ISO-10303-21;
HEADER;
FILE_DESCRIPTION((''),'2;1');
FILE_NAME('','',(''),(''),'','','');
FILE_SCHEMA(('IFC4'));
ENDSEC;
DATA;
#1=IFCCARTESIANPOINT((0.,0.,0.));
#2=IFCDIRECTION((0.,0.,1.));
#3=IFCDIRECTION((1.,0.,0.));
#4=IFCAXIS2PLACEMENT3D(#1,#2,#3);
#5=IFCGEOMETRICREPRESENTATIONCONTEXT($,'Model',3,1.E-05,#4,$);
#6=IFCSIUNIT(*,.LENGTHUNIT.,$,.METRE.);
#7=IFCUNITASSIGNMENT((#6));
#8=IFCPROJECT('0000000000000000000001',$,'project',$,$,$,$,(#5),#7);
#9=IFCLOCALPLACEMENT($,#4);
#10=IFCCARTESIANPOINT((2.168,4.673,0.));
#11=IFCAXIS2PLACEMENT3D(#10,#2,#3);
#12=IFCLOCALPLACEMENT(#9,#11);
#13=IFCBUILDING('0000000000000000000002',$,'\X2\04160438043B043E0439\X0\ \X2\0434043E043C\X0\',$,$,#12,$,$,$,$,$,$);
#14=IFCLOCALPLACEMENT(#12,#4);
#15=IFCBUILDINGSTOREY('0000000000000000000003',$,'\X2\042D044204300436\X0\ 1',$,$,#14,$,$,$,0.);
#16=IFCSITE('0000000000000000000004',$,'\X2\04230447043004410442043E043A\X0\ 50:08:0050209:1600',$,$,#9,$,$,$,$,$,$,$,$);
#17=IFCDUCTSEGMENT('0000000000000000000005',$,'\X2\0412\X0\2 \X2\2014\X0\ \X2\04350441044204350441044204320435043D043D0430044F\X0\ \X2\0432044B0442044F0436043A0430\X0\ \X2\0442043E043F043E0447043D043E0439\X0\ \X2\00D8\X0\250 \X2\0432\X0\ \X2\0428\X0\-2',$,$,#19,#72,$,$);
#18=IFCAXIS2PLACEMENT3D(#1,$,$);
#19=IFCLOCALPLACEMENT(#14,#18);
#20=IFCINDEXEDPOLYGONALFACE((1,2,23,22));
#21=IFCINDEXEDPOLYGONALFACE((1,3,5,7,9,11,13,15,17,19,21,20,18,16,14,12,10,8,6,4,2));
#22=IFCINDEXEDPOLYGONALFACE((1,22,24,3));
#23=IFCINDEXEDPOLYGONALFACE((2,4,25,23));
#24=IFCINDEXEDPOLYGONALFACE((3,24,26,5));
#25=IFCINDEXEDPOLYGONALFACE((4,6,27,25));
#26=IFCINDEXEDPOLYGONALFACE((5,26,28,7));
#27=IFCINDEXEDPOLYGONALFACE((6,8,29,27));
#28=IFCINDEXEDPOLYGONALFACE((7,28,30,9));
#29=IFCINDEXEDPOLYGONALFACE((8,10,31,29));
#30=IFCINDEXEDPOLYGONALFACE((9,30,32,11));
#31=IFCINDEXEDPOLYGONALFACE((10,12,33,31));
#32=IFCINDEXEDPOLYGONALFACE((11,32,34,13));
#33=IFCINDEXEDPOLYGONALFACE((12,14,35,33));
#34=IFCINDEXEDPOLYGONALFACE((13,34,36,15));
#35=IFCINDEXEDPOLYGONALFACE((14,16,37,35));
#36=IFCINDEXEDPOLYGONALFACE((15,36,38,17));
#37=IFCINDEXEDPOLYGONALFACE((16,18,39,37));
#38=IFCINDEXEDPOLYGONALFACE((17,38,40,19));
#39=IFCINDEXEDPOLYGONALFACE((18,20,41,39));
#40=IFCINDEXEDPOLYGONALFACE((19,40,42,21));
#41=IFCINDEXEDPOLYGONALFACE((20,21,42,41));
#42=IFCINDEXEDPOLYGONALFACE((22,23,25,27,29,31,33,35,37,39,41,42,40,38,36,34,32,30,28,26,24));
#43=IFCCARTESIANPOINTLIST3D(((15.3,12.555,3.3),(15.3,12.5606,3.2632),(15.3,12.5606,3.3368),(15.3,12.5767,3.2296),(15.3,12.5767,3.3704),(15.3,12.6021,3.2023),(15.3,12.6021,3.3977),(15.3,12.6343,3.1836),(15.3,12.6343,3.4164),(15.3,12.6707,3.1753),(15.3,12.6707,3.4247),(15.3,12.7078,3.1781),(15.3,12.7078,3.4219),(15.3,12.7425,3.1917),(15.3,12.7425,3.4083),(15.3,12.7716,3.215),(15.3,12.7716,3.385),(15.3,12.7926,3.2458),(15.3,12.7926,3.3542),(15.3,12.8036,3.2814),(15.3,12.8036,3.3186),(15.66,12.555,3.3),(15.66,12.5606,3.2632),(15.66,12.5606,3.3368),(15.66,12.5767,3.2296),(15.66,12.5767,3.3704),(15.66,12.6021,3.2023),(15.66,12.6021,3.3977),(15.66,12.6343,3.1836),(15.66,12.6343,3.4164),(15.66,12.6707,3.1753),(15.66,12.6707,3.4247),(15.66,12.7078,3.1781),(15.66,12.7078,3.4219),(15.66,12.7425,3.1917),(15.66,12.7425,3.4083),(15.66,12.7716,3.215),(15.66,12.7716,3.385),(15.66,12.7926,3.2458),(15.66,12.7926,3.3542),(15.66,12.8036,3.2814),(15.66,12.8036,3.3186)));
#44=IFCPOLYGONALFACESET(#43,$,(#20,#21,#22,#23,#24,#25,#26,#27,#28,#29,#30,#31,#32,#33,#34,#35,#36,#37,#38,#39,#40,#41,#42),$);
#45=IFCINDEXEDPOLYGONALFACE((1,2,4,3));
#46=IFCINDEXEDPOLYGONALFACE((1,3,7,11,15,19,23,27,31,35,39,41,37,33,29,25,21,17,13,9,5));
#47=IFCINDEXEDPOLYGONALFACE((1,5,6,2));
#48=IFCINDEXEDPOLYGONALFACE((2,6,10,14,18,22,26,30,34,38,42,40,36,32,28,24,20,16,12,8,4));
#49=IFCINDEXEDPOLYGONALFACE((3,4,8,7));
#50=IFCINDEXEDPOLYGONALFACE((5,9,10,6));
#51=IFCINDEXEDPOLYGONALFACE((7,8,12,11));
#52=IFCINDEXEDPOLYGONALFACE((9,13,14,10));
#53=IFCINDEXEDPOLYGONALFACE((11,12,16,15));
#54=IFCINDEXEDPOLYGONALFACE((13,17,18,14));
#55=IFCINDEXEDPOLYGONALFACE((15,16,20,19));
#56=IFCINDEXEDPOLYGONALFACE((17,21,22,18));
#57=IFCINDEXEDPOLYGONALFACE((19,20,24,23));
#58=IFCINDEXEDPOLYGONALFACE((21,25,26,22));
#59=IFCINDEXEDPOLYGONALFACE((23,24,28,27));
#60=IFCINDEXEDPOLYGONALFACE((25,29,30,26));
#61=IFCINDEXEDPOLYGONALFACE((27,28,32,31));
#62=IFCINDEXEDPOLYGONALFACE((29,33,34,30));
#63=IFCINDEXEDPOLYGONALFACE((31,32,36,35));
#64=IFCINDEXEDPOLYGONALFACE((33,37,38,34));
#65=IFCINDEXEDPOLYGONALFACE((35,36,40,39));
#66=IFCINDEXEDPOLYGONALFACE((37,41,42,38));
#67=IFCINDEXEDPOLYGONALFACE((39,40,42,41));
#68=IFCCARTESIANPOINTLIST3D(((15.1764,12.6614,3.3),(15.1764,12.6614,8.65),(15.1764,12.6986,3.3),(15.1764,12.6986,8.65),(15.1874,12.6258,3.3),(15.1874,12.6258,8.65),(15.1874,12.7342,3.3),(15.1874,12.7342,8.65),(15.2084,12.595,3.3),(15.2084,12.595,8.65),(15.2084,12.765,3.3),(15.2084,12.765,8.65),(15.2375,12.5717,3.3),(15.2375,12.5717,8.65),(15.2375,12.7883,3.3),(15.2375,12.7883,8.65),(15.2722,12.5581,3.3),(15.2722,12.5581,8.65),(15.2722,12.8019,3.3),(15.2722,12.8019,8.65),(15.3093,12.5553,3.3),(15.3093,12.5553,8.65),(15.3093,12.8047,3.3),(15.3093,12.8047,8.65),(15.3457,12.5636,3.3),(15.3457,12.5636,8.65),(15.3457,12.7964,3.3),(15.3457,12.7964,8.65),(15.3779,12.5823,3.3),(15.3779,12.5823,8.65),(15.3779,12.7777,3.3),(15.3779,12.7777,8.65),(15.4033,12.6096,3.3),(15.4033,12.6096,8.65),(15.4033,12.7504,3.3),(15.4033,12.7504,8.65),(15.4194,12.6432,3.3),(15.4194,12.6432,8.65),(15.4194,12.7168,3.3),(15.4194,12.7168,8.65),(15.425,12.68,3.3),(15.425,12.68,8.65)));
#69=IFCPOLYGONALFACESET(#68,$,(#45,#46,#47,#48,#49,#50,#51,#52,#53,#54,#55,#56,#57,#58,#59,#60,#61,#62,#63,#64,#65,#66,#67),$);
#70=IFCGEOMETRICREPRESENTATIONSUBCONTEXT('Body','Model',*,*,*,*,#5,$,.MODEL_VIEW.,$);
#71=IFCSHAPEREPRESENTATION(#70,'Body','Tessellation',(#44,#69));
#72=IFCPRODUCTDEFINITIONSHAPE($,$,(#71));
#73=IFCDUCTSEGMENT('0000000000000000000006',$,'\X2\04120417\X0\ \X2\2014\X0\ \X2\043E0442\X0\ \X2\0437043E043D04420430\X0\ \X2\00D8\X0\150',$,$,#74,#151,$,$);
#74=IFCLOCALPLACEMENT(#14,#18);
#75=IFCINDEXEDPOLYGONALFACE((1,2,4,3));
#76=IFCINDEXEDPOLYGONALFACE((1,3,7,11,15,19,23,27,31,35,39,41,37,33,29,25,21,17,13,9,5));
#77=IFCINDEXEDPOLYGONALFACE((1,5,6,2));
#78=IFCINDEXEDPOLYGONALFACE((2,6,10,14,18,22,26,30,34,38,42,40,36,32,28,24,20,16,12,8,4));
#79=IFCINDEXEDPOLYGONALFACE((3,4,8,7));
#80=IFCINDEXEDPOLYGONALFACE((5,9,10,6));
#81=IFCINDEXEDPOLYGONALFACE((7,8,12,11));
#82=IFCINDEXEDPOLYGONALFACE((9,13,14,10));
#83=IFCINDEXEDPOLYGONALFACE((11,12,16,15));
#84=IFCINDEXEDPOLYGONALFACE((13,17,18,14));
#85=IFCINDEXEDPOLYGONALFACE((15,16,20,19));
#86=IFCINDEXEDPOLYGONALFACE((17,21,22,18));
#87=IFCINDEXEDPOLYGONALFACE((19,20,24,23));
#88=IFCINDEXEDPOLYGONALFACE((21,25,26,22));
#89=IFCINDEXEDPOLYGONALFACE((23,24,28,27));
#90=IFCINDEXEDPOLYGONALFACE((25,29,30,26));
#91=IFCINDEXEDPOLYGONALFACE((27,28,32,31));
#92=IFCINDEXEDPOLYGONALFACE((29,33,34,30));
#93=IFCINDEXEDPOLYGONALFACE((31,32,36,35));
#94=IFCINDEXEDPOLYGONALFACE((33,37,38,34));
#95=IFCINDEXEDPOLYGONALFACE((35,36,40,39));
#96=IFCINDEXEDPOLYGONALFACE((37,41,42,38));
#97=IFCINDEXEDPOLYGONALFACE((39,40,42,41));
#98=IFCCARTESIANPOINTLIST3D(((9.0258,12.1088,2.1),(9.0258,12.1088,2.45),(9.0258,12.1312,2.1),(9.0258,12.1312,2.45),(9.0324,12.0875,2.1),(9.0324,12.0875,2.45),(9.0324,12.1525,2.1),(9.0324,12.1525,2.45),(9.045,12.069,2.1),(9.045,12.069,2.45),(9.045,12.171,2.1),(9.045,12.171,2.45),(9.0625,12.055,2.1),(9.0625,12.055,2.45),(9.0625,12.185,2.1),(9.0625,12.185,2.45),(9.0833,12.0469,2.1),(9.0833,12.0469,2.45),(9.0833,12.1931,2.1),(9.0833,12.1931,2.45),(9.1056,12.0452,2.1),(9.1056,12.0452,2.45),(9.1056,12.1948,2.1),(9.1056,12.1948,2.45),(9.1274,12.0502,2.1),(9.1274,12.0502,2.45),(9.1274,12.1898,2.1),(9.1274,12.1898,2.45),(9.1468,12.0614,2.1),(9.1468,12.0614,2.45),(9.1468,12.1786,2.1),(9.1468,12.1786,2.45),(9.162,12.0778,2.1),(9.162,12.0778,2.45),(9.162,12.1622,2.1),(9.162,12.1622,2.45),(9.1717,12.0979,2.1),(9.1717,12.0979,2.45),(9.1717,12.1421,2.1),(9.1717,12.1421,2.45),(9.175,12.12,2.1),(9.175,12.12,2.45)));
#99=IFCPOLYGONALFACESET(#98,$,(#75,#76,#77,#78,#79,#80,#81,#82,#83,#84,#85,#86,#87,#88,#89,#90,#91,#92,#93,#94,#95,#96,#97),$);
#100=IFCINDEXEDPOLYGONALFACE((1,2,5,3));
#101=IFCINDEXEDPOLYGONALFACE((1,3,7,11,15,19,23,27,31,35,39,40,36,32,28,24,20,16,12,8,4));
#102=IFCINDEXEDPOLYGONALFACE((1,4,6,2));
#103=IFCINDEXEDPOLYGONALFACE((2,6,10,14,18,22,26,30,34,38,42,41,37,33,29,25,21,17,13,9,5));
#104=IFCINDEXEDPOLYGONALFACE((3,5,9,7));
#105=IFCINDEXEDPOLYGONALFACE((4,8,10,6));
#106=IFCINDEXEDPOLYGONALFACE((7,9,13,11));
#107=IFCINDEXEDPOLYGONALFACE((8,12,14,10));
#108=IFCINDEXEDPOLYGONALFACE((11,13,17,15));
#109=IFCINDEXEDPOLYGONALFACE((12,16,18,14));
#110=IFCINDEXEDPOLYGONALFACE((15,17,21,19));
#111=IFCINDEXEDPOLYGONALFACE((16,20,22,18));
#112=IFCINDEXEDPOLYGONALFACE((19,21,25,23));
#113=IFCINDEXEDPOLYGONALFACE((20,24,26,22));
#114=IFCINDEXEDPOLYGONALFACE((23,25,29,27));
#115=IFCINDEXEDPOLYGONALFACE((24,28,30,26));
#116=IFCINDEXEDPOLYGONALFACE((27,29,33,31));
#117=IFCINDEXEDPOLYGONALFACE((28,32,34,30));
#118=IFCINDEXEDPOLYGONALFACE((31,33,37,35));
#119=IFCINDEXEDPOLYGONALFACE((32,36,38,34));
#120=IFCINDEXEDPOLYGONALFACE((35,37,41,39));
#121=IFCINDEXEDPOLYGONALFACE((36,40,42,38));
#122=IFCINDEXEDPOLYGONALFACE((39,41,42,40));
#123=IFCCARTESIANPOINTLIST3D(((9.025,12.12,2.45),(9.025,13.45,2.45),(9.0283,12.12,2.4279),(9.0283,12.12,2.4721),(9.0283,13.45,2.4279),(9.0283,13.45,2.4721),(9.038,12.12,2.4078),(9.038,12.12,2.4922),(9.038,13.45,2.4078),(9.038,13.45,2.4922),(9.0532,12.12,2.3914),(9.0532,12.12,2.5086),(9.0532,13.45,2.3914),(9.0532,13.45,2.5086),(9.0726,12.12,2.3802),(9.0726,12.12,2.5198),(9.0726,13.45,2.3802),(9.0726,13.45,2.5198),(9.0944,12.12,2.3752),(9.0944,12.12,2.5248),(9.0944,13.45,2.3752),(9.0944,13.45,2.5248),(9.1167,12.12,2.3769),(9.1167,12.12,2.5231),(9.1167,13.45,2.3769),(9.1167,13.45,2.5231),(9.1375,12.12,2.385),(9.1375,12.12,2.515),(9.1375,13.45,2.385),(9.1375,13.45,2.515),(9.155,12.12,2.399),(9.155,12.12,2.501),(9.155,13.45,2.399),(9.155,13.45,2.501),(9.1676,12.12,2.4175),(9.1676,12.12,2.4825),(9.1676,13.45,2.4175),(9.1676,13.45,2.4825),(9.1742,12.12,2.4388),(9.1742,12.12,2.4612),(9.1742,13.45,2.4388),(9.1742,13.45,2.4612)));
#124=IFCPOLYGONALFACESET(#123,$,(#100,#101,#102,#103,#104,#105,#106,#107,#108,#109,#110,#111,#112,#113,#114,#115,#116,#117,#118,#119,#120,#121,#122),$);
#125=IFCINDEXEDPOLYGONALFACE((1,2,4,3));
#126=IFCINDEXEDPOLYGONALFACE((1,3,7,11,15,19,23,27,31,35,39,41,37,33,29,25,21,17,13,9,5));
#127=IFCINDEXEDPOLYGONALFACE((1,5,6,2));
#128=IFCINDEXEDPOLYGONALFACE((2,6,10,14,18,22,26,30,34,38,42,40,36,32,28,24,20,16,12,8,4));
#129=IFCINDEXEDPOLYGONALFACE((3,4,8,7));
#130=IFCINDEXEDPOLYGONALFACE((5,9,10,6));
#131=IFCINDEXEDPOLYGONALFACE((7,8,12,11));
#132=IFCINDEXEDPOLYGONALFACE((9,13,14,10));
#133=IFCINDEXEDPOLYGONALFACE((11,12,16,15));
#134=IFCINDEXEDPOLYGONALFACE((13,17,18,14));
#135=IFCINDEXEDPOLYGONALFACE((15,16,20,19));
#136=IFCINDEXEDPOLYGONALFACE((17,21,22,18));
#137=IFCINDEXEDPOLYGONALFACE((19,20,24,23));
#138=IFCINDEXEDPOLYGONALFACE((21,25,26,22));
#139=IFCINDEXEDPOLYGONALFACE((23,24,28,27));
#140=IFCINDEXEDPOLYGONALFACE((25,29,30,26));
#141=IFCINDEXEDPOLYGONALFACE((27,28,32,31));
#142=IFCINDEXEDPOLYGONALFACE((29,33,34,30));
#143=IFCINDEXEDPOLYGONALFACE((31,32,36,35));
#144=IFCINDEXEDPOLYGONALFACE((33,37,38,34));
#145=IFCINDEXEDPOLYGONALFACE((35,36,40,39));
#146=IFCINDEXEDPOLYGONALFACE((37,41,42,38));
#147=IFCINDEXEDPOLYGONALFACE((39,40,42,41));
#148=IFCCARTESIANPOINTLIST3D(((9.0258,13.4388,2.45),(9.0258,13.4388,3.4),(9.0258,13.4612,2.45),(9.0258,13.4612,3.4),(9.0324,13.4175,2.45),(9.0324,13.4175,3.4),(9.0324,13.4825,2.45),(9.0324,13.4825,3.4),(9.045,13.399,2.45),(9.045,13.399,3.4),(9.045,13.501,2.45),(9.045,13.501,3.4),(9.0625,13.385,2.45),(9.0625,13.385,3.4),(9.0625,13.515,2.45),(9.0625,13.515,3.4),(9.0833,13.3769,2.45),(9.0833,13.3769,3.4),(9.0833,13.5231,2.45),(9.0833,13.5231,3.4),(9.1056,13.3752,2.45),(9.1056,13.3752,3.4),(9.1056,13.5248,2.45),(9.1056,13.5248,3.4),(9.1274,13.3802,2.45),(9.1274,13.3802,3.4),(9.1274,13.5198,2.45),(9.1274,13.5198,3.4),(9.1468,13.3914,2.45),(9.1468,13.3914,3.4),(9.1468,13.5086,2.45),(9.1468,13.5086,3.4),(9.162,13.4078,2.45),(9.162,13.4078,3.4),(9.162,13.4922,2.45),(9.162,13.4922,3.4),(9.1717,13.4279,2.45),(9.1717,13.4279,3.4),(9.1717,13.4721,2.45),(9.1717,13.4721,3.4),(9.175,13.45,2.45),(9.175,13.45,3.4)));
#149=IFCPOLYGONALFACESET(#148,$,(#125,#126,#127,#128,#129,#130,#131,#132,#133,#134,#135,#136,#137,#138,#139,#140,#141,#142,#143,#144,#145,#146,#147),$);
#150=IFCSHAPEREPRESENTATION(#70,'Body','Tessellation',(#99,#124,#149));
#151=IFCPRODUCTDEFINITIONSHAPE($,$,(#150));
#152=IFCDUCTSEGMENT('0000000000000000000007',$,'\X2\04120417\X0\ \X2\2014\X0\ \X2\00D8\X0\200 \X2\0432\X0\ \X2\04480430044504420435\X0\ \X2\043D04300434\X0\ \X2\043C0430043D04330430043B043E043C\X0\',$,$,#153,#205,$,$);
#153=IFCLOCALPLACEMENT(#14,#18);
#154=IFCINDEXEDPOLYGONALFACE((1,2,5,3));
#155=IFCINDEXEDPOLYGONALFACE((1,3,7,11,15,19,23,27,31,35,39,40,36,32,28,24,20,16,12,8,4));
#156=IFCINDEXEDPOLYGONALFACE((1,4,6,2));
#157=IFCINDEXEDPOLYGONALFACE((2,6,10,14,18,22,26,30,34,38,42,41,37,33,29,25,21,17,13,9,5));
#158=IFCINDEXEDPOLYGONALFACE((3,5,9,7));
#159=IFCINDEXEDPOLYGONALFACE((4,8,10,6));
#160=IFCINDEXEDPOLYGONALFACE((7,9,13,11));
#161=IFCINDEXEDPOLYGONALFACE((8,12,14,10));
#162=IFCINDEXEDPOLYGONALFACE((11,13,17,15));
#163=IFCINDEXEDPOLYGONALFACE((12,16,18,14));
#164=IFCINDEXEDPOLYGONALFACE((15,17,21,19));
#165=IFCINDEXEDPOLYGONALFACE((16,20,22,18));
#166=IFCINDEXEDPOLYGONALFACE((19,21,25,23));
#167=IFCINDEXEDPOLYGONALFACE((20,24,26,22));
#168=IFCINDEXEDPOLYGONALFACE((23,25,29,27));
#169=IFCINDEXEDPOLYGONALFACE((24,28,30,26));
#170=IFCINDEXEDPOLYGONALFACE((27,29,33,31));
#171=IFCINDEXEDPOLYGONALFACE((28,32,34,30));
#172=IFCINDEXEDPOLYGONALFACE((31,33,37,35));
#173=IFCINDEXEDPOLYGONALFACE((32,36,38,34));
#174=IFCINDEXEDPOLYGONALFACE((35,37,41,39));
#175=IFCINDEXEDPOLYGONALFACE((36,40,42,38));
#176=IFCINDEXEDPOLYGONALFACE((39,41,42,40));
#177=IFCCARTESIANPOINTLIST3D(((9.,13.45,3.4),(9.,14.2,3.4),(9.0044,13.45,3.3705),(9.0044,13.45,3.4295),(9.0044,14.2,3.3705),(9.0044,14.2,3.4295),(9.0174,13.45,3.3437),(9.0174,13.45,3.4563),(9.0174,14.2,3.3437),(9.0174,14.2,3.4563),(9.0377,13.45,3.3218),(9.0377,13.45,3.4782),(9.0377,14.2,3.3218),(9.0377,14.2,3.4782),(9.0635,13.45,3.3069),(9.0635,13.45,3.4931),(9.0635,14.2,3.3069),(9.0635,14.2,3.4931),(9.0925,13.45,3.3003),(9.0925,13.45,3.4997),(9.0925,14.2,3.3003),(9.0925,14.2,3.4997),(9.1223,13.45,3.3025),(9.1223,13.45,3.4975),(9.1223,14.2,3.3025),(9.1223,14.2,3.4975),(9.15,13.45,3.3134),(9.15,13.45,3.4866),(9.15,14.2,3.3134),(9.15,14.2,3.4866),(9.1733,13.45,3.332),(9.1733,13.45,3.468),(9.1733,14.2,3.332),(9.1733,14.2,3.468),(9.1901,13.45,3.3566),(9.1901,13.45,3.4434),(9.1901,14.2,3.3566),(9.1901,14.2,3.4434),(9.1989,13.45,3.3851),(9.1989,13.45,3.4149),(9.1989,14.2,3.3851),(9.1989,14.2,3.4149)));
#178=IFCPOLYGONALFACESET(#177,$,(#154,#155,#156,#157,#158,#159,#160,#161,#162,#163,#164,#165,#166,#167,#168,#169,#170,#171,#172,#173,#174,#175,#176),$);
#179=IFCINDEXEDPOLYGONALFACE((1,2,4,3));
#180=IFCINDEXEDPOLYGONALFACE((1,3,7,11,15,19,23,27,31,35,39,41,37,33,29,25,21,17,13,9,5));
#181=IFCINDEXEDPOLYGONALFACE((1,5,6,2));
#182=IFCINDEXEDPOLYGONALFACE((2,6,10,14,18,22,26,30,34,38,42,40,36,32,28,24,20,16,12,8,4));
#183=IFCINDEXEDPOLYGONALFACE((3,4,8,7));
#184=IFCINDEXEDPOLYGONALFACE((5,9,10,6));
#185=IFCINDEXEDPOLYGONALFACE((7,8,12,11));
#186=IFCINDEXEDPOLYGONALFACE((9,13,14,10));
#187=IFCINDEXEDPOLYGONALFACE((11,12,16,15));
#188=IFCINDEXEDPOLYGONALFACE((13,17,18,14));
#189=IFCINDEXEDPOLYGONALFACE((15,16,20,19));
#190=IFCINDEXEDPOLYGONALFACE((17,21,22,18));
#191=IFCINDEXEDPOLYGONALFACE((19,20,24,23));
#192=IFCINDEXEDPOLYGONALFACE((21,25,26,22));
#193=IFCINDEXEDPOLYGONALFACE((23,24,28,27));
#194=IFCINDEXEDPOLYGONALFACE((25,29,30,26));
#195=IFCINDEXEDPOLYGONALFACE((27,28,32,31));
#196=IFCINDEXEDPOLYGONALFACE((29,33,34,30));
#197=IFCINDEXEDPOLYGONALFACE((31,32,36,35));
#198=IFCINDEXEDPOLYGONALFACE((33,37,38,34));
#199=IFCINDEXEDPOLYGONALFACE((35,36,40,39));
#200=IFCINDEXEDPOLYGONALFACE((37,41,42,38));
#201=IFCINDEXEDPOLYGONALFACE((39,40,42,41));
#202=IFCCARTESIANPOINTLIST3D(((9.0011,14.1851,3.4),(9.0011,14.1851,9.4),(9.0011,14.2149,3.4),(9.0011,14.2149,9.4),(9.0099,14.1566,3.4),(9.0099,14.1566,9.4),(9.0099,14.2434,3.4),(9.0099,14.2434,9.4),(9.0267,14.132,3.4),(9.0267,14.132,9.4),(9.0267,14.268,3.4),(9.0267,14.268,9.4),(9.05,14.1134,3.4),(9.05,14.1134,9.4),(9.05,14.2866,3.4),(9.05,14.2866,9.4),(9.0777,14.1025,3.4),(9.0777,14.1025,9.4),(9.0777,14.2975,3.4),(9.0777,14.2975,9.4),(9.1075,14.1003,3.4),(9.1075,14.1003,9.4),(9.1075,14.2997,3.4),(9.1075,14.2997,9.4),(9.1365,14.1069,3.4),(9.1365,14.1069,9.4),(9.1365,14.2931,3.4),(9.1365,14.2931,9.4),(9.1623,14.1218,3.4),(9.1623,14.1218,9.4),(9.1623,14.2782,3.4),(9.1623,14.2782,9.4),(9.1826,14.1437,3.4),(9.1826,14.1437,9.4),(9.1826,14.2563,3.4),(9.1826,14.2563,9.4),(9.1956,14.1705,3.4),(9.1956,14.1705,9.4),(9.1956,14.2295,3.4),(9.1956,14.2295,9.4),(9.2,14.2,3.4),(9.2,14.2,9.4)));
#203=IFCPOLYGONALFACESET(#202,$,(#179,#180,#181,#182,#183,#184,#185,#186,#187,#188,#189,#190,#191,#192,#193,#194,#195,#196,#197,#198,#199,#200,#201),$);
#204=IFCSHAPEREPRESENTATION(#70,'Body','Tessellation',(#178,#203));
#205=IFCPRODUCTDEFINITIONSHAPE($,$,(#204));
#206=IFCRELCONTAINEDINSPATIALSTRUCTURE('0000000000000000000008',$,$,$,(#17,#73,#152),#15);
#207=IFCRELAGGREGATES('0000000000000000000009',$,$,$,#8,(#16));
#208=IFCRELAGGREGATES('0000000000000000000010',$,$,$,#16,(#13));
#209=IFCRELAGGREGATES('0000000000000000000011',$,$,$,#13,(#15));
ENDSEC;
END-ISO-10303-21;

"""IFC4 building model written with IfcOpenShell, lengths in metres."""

from ifc_helpers import new_model, si_unit, frame, origin_with_axes, origin_2d, place, context, subcontext, project, spatial, circle, extrude, element, save


model = new_model("IFC4")

# Units and contexts
model_context = context("Model", 3, precision=1e-05, world=origin_with_axes())
body_context = subcontext(model_context, "Body", "Model", "MODEL_VIEW")
ifc_project = project(units=[si_unit("LENGTHUNIT", "METRE")], contexts=[model_context])

# Site, building, storey
site_placement = place(None, origin_with_axes())
site = spatial("IfcSite", under=ifc_project, at=site_placement, Name="Участок 50:08:0050209:1600")
building_placement = place(site_placement, frame((2.168, 4.673, 0.0), z_axis=(0.0, 0.0, 1.0), x_axis=(1.0, 0.0, 0.0)))
building = spatial("IfcBuilding", under=site, at=building_placement, Name="Жилой дом")
storey_placement = place(building_placement, origin_with_axes())
storey = spatial("IfcBuildingStorey", under=building, at=storey_placement, Name="Этаж 1", Elevation=0.0)

# Duct segments
duct_segment_1_placement = place(storey_placement, origin_with_axes())
element("IfcDuctSegment", 1, at=duct_segment_1_placement, inside=storey, Name="В2 — естественная вытяжка топочной Ø250 в Ш-2", context=body_context, shape_type="SweptSolid", body=[
    extrude(circle(Radius=0.125, at=origin_2d()), frame((15.66, 12.68, 3.3), z_axis=(-1.0, 0.0, 0.0), x_axis=(0.0, -1.0, 0.0)), (0.0, 0.0, 1.0), 0.36),
    extrude(circle(Radius=0.125, at=origin_2d()), frame((15.3, 12.68, 3.3), z_axis=(0.0, 0.0, 1.0), x_axis=(1.0, 0.0, 0.0)), (0.0, 0.0, 1.0), 5.35),
])
duct_segment_2_placement = place(storey_placement, origin_with_axes())
element("IfcDuctSegment", 2, at=duct_segment_2_placement, inside=storey, Name="ВЗ — от зонта Ø150", context=body_context, shape_type="SweptSolid", body=[
    extrude(circle(Radius=0.075, at=origin_2d()), frame((9.1, 12.12, 2.1), z_axis=(0.0, 0.0, 1.0), x_axis=(1.0, 0.0, 0.0)), (0.0, 0.0, 1.0), 0.35),
    extrude(circle(Radius=0.075, at=origin_2d()), frame((9.1, 12.12, 2.45), z_axis=(0.0, 1.0, 0.0), x_axis=(-1.0, 0.0, 0.0)), (0.0, 0.0, 1.0), 1.33),
    extrude(circle(Radius=0.075, at=origin_2d()), frame((9.1, 13.45, 2.45), z_axis=(0.0, 0.0, 1.0), x_axis=(1.0, 0.0, 0.0)), (0.0, 0.0, 1.0), 0.95),
])
duct_segment_3_placement = place(storey_placement, origin_with_axes())
element("IfcDuctSegment", 3, at=duct_segment_3_placement, inside=storey, Name="ВЗ — Ø200 в шахте над мангалом", context=body_context, shape_type="SweptSolid", body=[
    extrude(circle(Radius=0.1, at=origin_2d()), frame((9.1, 13.45, 3.4), z_axis=(0.0, 1.0, 0.0), x_axis=(-1.0, 0.0, 0.0)), (0.0, 0.0, 1.0), 0.75),
    extrude(circle(Radius=0.1, at=origin_2d()), frame((9.1, 14.2, 3.4), z_axis=(0.0, 0.0, 1.0), x_axis=(1.0, 0.0, 0.0)), (0.0, 0.0, 1.0), 6.0),
])

save(model, "model.ifc")
